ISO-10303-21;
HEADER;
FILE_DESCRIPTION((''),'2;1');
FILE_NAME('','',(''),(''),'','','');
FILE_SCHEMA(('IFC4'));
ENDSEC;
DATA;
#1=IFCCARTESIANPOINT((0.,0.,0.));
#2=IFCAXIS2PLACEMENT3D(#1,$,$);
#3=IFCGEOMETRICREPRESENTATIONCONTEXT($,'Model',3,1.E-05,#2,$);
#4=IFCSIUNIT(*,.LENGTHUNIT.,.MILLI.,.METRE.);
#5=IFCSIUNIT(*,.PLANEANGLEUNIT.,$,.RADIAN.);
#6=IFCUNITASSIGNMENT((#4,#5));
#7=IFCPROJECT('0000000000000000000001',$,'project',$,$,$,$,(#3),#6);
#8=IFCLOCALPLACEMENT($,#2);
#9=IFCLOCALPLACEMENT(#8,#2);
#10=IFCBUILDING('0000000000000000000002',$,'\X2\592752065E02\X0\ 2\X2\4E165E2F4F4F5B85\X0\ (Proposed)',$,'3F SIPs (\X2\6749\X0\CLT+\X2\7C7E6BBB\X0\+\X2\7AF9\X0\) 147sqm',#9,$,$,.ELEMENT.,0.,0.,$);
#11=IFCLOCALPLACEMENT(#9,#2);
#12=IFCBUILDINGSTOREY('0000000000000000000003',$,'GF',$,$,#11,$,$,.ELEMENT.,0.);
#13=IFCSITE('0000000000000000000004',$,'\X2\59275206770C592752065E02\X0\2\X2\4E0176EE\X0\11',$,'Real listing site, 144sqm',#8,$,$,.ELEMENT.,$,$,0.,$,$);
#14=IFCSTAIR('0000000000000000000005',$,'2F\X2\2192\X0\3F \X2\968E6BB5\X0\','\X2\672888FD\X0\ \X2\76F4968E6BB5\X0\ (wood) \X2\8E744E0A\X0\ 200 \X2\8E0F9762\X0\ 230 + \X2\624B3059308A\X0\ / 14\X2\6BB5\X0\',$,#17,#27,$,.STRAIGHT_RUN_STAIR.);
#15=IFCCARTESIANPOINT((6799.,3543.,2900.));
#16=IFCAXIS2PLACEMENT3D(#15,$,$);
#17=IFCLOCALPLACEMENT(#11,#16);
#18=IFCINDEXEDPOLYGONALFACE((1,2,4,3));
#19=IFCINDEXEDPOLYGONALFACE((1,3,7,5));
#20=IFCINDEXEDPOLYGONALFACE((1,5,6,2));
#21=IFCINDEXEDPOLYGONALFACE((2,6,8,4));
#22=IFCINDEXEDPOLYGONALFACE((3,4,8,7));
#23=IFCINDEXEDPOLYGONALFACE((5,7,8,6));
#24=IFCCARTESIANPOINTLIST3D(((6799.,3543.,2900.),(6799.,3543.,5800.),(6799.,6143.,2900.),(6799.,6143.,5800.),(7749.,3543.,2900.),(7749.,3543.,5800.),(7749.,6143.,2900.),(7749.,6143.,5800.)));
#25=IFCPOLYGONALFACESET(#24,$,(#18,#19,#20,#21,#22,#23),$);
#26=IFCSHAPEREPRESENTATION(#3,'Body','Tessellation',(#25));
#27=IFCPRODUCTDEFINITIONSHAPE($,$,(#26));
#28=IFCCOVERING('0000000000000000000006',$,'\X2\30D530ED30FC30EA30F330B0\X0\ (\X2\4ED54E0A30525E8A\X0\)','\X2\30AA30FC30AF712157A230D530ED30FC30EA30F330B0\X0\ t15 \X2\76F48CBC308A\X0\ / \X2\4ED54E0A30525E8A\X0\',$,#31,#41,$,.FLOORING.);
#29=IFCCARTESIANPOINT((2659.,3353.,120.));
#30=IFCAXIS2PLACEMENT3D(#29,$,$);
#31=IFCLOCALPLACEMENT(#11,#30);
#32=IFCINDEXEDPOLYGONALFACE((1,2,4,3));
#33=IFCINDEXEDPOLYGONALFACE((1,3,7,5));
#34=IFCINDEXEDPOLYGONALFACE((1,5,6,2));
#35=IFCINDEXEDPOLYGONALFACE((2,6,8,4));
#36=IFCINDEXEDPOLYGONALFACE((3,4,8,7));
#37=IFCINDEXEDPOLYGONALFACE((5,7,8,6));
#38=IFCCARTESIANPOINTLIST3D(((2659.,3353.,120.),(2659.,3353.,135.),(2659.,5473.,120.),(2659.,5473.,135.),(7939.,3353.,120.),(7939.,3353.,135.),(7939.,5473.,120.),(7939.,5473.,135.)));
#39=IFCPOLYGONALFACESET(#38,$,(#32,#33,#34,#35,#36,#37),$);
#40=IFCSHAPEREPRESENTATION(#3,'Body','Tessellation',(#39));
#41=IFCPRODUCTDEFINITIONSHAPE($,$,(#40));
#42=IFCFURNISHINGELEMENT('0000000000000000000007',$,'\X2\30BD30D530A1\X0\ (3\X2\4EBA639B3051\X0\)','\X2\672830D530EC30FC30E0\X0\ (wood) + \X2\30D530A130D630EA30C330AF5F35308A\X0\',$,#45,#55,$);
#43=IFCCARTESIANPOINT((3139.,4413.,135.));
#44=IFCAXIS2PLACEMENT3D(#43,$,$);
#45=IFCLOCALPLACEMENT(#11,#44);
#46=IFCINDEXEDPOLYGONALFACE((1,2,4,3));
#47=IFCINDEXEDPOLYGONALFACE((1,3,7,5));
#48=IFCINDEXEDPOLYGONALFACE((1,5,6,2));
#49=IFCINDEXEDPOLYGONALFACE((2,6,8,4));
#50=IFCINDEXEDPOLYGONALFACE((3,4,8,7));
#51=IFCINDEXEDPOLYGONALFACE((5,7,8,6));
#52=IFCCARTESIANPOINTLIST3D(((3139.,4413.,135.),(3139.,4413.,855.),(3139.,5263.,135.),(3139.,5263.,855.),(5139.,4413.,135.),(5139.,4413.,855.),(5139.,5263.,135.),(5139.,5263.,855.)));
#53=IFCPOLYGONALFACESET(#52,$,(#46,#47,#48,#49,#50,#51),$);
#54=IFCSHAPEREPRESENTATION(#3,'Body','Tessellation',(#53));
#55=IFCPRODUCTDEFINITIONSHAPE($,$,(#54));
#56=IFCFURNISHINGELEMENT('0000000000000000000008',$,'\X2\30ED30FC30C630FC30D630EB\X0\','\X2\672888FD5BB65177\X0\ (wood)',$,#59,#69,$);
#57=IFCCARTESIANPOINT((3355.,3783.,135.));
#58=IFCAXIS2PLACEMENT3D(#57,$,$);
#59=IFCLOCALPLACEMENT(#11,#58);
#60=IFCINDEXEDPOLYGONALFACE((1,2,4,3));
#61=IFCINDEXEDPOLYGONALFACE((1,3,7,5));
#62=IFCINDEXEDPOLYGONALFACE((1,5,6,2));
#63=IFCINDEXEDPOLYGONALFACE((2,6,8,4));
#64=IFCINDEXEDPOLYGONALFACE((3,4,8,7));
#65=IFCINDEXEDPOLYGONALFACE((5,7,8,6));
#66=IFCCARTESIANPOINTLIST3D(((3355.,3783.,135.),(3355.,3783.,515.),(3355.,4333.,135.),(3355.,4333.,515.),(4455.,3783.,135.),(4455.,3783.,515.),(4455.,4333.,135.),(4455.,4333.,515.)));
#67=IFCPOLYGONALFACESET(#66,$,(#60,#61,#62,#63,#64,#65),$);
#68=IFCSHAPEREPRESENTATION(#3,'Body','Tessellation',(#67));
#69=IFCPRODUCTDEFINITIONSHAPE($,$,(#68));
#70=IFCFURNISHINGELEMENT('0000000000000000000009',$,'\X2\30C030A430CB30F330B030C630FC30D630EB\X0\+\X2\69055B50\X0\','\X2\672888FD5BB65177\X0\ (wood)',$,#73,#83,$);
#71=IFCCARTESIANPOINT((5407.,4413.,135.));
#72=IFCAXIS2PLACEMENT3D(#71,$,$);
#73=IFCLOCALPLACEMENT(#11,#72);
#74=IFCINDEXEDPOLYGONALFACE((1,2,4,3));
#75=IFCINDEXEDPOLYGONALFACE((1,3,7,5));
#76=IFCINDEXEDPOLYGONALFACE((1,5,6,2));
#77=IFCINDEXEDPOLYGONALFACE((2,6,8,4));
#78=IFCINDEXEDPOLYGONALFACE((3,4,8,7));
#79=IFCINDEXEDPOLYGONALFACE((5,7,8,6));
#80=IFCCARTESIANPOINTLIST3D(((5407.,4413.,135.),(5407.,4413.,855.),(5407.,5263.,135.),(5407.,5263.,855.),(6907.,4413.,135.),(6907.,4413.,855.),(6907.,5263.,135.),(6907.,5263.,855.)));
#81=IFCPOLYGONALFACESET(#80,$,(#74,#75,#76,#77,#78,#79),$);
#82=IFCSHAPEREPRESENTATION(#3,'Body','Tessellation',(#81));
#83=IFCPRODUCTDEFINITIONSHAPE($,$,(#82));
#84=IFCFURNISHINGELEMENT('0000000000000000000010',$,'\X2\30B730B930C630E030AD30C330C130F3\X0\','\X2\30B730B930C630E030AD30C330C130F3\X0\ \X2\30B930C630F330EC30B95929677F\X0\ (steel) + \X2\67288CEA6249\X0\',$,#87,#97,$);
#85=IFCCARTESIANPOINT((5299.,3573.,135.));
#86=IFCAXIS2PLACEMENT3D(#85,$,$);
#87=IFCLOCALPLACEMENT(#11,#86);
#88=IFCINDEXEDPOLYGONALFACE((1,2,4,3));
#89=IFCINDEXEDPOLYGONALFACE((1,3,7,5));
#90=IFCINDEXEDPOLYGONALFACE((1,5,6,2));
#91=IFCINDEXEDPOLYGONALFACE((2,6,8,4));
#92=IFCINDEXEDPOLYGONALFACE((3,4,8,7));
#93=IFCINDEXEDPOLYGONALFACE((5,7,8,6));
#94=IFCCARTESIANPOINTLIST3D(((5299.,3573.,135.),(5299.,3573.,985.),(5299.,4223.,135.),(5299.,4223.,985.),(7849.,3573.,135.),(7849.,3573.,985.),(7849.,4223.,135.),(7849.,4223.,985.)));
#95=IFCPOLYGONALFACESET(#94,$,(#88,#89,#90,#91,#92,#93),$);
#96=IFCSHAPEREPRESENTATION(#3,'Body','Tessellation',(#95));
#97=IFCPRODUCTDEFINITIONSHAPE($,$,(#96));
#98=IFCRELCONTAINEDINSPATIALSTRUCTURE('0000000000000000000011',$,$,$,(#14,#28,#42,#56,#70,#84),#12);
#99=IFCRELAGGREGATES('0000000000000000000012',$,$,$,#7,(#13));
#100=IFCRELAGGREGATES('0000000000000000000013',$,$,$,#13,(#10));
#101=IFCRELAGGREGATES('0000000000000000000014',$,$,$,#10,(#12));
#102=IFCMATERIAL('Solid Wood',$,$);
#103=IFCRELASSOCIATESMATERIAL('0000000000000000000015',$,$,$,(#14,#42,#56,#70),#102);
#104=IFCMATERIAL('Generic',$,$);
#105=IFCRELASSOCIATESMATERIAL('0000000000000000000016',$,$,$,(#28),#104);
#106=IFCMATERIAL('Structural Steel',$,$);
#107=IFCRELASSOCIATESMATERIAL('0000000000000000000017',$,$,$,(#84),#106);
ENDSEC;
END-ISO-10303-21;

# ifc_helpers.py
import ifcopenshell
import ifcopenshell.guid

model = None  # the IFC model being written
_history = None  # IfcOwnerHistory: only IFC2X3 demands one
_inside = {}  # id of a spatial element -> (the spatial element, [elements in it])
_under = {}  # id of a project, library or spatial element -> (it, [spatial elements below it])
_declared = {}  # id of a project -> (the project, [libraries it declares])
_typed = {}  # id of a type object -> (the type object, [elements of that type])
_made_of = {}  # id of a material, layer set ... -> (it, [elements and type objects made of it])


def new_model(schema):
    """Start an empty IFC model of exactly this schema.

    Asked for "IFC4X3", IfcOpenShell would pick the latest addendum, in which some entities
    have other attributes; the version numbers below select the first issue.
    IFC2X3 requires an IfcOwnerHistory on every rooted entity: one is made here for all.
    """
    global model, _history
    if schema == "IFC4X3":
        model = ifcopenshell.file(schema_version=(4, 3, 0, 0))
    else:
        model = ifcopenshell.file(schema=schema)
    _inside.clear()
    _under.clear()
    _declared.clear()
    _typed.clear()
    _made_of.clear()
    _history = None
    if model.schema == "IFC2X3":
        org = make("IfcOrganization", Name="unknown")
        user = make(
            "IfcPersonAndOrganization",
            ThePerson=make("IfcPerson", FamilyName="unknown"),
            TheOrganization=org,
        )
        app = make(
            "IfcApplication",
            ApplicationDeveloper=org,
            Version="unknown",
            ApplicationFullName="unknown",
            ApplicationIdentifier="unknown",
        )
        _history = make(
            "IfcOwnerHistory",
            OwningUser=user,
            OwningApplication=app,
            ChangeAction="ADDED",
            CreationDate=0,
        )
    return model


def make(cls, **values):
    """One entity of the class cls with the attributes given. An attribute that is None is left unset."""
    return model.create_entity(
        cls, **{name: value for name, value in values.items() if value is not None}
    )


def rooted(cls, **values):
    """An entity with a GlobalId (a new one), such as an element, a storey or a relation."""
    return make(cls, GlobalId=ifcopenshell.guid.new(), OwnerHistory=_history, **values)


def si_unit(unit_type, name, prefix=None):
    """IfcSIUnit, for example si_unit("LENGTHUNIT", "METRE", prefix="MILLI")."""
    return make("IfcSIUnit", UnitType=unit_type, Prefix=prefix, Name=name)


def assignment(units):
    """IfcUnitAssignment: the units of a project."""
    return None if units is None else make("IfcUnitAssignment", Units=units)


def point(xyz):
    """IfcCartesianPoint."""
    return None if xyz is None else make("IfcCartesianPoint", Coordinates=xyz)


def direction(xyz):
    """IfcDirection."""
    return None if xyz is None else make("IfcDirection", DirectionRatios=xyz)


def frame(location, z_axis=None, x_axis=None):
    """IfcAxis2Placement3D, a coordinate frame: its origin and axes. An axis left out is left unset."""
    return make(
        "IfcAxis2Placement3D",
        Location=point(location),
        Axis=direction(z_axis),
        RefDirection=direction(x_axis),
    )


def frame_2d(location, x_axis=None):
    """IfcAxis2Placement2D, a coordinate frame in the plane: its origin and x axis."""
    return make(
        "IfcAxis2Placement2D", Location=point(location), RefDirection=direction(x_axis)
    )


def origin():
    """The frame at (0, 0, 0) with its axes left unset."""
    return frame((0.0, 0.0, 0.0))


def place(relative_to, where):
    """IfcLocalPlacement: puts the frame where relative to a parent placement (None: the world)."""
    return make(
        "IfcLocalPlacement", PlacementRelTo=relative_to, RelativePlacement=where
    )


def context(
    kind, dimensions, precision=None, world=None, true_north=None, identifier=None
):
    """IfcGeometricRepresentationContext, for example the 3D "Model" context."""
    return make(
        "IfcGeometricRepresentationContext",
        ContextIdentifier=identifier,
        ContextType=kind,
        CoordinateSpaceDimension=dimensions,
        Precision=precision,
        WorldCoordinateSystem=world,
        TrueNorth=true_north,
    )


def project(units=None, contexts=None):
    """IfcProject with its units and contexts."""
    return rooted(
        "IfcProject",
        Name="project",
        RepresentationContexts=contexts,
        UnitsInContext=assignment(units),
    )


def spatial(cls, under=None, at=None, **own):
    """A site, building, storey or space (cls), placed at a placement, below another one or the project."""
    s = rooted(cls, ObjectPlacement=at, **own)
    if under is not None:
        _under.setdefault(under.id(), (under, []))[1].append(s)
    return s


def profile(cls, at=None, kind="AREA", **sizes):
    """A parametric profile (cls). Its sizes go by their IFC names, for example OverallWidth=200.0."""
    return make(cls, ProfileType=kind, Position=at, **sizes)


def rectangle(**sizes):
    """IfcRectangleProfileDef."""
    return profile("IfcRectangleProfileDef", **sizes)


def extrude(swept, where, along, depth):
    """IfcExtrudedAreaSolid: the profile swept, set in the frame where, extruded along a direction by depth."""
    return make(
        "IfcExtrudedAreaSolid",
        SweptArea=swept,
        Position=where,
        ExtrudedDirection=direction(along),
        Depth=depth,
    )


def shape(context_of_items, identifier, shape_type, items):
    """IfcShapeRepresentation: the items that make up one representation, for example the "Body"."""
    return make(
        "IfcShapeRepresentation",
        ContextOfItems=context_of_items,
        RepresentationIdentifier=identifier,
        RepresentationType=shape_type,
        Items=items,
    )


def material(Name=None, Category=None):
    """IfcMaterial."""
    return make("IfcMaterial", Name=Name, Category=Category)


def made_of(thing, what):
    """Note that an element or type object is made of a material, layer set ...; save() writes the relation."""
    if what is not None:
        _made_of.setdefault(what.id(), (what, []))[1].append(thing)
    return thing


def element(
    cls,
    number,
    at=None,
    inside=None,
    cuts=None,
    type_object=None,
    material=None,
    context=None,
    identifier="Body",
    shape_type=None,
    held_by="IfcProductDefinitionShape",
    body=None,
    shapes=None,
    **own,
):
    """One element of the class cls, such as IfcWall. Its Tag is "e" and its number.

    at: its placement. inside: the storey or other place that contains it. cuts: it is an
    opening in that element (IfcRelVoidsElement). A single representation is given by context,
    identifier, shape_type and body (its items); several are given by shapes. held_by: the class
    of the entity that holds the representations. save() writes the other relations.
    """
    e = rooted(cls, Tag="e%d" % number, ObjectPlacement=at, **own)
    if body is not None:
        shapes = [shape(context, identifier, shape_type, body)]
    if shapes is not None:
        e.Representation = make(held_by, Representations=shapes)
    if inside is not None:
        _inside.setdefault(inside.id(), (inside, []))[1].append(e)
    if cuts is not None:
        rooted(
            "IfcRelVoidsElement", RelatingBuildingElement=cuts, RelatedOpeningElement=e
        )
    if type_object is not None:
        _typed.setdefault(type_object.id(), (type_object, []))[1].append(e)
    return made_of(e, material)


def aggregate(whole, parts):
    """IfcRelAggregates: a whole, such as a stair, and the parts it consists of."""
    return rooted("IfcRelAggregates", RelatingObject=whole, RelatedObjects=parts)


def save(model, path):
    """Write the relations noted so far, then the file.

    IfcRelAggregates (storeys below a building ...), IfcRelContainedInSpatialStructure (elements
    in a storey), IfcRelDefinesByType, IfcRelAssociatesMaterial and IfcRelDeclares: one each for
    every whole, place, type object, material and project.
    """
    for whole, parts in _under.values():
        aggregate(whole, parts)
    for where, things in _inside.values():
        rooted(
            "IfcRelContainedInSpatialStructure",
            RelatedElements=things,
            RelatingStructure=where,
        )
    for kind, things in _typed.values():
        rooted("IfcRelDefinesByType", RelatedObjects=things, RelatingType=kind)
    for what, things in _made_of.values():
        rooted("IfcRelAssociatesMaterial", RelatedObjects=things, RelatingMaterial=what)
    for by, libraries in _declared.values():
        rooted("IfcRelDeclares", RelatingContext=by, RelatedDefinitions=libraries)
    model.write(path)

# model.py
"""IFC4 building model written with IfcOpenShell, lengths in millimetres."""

from ifc_helpers import new_model, si_unit, frame, frame_2d, origin, place, context, project, spatial, rectangle, extrude, material, element, save


model = new_model("IFC4")

# Units and contexts
model_context = context("Model", 3, precision=1e-05, world=origin())
ifc_project = project(units=[si_unit("LENGTHUNIT", "METRE", prefix="MILLI"), si_unit("PLANEANGLEUNIT", "RADIAN")], contexts=[model_context])

# Site, building, storey
site_placement = place(None, origin())
site = spatial("IfcSite", under=ifc_project, at=site_placement, Name="大分県大分市2丁目11", ObjectType="Real listing site, 144sqm", CompositionType="ELEMENT", RefElevation=0.0)
building_placement = place(site_placement, origin())
building = spatial("IfcBuilding", under=site, at=building_placement, Name="大分市 2世帯住宅 (Proposed)", ObjectType="3F SIPs (杉CLT+籾殻+竹) 147sqm", CompositionType="ELEMENT", ElevationOfRefHeight=0.0, ElevationOfTerrain=0.0)
storey_placement = place(building_placement, origin())
storey = spatial("IfcBuildingStorey", under=building, at=storey_placement, Name="GF", CompositionType="ELEMENT", Elevation=0.0)

# Shared definitions
ifc_material_1 = material(Name="Solid Wood")
ifc_material_2 = material(Name="Generic")

# Stair
stair_1_placement = place(storey_placement, frame((6799.0, 3543.0, 2900.0)))
element("IfcStair", 1, at=stair_1_placement, inside=storey, material=ifc_material_1, Name="2F→3F 階段", Description="木製 直階段 (wood) 蹴上 200 踏面 230 + 手すり / 14段", PredefinedType="STRAIGHT_RUN_STAIR", context=model_context, shape_type="SweptSolid", body=[
    extrude(rectangle(XDim=950.0, YDim=2600.0, at=frame_2d((475.0, 1300.0))), frame((6799.0, 3543.0, 2900.0)), (0.0, 0.0, 1.0), 2900.0),
])

# Covering
covering_placement = place(storey_placement, frame((2659.0, 3353.0, 120.0)))
element("IfcCovering", 2, at=covering_placement, inside=storey, material=ifc_material_2, Name="フローリング (仕上げ床)", Description="オーク無垢フローリング t15 直貼り / 仕上げ床", PredefinedType="FLOORING", context=model_context, shape_type="SweptSolid", body=[
    extrude(rectangle(XDim=5280.0, YDim=2120.0, at=frame_2d((2640.0, 1060.0))), frame((2659.0, 3353.0, 120.0)), (0.0, 0.0, 1.0), 15.0),
])

# Furnishing elements
furnishing_1_placement = place(storey_placement, frame((3139.0, 4413.0, 135.0)))
element("IfcFurnishingElement", 3, at=furnishing_1_placement, inside=storey, material=ifc_material_1, Name="ソファ (3人掛け)", Description="木フレーム (wood) + ファブリック張り", context=model_context, shape_type="SweptSolid", body=[
    extrude(rectangle(XDim=2000.0, YDim=850.0, at=frame_2d((1000.0, 425.0))), frame((3139.0, 4413.0, 135.0)), (0.0, 0.0, 1.0), 720.0),
])
furnishing_2_placement = place(storey_placement, frame((3355.0, 3783.0, 135.0)))
element("IfcFurnishingElement", 4, at=furnishing_2_placement, inside=storey, material=ifc_material_1, Name="ローテーブル", Description="木製家具 (wood)", context=model_context, shape_type="SweptSolid", body=[
    extrude(rectangle(XDim=1100.0, YDim=550.0, at=frame_2d((550.0, 275.0))), frame((3355.0, 3783.0, 135.0)), (0.0, 0.0, 1.0), 380.0),
])
furnishing_3_placement = place(storey_placement, frame((5407.0, 4413.0, 135.0)))
element("IfcFurnishingElement", 5, at=furnishing_3_placement, inside=storey, material=ifc_material_1, Name="ダイニングテーブル+椅子", Description="木製家具 (wood)", context=model_context, shape_type="SweptSolid", body=[
    extrude(rectangle(XDim=1500.0, YDim=850.0, at=frame_2d((750.0, 425.0))), frame((5407.0, 4413.0, 135.0)), (0.0, 0.0, 1.0), 720.0),
])
ifc_material_3 = material(Name="Structural Steel")
furnishing_4_placement = place(storey_placement, frame((5299.0, 3573.0, 135.0)))
element("IfcFurnishingElement", 6, at=furnishing_4_placement, inside=storey, material=ifc_material_3, Name="システムキッチン", Description="システムキッチン ステンレス天板 (steel) + 木質扉", context=model_context, shape_type="SweptSolid", body=[
    extrude(rectangle(XDim=2550.0, YDim=650.0, at=frame_2d((1275.0, 325.0))), frame((5299.0, 3573.0, 135.0)), (0.0, 0.0, 1.0), 850.0),
])

save(model, "model.ifc")
